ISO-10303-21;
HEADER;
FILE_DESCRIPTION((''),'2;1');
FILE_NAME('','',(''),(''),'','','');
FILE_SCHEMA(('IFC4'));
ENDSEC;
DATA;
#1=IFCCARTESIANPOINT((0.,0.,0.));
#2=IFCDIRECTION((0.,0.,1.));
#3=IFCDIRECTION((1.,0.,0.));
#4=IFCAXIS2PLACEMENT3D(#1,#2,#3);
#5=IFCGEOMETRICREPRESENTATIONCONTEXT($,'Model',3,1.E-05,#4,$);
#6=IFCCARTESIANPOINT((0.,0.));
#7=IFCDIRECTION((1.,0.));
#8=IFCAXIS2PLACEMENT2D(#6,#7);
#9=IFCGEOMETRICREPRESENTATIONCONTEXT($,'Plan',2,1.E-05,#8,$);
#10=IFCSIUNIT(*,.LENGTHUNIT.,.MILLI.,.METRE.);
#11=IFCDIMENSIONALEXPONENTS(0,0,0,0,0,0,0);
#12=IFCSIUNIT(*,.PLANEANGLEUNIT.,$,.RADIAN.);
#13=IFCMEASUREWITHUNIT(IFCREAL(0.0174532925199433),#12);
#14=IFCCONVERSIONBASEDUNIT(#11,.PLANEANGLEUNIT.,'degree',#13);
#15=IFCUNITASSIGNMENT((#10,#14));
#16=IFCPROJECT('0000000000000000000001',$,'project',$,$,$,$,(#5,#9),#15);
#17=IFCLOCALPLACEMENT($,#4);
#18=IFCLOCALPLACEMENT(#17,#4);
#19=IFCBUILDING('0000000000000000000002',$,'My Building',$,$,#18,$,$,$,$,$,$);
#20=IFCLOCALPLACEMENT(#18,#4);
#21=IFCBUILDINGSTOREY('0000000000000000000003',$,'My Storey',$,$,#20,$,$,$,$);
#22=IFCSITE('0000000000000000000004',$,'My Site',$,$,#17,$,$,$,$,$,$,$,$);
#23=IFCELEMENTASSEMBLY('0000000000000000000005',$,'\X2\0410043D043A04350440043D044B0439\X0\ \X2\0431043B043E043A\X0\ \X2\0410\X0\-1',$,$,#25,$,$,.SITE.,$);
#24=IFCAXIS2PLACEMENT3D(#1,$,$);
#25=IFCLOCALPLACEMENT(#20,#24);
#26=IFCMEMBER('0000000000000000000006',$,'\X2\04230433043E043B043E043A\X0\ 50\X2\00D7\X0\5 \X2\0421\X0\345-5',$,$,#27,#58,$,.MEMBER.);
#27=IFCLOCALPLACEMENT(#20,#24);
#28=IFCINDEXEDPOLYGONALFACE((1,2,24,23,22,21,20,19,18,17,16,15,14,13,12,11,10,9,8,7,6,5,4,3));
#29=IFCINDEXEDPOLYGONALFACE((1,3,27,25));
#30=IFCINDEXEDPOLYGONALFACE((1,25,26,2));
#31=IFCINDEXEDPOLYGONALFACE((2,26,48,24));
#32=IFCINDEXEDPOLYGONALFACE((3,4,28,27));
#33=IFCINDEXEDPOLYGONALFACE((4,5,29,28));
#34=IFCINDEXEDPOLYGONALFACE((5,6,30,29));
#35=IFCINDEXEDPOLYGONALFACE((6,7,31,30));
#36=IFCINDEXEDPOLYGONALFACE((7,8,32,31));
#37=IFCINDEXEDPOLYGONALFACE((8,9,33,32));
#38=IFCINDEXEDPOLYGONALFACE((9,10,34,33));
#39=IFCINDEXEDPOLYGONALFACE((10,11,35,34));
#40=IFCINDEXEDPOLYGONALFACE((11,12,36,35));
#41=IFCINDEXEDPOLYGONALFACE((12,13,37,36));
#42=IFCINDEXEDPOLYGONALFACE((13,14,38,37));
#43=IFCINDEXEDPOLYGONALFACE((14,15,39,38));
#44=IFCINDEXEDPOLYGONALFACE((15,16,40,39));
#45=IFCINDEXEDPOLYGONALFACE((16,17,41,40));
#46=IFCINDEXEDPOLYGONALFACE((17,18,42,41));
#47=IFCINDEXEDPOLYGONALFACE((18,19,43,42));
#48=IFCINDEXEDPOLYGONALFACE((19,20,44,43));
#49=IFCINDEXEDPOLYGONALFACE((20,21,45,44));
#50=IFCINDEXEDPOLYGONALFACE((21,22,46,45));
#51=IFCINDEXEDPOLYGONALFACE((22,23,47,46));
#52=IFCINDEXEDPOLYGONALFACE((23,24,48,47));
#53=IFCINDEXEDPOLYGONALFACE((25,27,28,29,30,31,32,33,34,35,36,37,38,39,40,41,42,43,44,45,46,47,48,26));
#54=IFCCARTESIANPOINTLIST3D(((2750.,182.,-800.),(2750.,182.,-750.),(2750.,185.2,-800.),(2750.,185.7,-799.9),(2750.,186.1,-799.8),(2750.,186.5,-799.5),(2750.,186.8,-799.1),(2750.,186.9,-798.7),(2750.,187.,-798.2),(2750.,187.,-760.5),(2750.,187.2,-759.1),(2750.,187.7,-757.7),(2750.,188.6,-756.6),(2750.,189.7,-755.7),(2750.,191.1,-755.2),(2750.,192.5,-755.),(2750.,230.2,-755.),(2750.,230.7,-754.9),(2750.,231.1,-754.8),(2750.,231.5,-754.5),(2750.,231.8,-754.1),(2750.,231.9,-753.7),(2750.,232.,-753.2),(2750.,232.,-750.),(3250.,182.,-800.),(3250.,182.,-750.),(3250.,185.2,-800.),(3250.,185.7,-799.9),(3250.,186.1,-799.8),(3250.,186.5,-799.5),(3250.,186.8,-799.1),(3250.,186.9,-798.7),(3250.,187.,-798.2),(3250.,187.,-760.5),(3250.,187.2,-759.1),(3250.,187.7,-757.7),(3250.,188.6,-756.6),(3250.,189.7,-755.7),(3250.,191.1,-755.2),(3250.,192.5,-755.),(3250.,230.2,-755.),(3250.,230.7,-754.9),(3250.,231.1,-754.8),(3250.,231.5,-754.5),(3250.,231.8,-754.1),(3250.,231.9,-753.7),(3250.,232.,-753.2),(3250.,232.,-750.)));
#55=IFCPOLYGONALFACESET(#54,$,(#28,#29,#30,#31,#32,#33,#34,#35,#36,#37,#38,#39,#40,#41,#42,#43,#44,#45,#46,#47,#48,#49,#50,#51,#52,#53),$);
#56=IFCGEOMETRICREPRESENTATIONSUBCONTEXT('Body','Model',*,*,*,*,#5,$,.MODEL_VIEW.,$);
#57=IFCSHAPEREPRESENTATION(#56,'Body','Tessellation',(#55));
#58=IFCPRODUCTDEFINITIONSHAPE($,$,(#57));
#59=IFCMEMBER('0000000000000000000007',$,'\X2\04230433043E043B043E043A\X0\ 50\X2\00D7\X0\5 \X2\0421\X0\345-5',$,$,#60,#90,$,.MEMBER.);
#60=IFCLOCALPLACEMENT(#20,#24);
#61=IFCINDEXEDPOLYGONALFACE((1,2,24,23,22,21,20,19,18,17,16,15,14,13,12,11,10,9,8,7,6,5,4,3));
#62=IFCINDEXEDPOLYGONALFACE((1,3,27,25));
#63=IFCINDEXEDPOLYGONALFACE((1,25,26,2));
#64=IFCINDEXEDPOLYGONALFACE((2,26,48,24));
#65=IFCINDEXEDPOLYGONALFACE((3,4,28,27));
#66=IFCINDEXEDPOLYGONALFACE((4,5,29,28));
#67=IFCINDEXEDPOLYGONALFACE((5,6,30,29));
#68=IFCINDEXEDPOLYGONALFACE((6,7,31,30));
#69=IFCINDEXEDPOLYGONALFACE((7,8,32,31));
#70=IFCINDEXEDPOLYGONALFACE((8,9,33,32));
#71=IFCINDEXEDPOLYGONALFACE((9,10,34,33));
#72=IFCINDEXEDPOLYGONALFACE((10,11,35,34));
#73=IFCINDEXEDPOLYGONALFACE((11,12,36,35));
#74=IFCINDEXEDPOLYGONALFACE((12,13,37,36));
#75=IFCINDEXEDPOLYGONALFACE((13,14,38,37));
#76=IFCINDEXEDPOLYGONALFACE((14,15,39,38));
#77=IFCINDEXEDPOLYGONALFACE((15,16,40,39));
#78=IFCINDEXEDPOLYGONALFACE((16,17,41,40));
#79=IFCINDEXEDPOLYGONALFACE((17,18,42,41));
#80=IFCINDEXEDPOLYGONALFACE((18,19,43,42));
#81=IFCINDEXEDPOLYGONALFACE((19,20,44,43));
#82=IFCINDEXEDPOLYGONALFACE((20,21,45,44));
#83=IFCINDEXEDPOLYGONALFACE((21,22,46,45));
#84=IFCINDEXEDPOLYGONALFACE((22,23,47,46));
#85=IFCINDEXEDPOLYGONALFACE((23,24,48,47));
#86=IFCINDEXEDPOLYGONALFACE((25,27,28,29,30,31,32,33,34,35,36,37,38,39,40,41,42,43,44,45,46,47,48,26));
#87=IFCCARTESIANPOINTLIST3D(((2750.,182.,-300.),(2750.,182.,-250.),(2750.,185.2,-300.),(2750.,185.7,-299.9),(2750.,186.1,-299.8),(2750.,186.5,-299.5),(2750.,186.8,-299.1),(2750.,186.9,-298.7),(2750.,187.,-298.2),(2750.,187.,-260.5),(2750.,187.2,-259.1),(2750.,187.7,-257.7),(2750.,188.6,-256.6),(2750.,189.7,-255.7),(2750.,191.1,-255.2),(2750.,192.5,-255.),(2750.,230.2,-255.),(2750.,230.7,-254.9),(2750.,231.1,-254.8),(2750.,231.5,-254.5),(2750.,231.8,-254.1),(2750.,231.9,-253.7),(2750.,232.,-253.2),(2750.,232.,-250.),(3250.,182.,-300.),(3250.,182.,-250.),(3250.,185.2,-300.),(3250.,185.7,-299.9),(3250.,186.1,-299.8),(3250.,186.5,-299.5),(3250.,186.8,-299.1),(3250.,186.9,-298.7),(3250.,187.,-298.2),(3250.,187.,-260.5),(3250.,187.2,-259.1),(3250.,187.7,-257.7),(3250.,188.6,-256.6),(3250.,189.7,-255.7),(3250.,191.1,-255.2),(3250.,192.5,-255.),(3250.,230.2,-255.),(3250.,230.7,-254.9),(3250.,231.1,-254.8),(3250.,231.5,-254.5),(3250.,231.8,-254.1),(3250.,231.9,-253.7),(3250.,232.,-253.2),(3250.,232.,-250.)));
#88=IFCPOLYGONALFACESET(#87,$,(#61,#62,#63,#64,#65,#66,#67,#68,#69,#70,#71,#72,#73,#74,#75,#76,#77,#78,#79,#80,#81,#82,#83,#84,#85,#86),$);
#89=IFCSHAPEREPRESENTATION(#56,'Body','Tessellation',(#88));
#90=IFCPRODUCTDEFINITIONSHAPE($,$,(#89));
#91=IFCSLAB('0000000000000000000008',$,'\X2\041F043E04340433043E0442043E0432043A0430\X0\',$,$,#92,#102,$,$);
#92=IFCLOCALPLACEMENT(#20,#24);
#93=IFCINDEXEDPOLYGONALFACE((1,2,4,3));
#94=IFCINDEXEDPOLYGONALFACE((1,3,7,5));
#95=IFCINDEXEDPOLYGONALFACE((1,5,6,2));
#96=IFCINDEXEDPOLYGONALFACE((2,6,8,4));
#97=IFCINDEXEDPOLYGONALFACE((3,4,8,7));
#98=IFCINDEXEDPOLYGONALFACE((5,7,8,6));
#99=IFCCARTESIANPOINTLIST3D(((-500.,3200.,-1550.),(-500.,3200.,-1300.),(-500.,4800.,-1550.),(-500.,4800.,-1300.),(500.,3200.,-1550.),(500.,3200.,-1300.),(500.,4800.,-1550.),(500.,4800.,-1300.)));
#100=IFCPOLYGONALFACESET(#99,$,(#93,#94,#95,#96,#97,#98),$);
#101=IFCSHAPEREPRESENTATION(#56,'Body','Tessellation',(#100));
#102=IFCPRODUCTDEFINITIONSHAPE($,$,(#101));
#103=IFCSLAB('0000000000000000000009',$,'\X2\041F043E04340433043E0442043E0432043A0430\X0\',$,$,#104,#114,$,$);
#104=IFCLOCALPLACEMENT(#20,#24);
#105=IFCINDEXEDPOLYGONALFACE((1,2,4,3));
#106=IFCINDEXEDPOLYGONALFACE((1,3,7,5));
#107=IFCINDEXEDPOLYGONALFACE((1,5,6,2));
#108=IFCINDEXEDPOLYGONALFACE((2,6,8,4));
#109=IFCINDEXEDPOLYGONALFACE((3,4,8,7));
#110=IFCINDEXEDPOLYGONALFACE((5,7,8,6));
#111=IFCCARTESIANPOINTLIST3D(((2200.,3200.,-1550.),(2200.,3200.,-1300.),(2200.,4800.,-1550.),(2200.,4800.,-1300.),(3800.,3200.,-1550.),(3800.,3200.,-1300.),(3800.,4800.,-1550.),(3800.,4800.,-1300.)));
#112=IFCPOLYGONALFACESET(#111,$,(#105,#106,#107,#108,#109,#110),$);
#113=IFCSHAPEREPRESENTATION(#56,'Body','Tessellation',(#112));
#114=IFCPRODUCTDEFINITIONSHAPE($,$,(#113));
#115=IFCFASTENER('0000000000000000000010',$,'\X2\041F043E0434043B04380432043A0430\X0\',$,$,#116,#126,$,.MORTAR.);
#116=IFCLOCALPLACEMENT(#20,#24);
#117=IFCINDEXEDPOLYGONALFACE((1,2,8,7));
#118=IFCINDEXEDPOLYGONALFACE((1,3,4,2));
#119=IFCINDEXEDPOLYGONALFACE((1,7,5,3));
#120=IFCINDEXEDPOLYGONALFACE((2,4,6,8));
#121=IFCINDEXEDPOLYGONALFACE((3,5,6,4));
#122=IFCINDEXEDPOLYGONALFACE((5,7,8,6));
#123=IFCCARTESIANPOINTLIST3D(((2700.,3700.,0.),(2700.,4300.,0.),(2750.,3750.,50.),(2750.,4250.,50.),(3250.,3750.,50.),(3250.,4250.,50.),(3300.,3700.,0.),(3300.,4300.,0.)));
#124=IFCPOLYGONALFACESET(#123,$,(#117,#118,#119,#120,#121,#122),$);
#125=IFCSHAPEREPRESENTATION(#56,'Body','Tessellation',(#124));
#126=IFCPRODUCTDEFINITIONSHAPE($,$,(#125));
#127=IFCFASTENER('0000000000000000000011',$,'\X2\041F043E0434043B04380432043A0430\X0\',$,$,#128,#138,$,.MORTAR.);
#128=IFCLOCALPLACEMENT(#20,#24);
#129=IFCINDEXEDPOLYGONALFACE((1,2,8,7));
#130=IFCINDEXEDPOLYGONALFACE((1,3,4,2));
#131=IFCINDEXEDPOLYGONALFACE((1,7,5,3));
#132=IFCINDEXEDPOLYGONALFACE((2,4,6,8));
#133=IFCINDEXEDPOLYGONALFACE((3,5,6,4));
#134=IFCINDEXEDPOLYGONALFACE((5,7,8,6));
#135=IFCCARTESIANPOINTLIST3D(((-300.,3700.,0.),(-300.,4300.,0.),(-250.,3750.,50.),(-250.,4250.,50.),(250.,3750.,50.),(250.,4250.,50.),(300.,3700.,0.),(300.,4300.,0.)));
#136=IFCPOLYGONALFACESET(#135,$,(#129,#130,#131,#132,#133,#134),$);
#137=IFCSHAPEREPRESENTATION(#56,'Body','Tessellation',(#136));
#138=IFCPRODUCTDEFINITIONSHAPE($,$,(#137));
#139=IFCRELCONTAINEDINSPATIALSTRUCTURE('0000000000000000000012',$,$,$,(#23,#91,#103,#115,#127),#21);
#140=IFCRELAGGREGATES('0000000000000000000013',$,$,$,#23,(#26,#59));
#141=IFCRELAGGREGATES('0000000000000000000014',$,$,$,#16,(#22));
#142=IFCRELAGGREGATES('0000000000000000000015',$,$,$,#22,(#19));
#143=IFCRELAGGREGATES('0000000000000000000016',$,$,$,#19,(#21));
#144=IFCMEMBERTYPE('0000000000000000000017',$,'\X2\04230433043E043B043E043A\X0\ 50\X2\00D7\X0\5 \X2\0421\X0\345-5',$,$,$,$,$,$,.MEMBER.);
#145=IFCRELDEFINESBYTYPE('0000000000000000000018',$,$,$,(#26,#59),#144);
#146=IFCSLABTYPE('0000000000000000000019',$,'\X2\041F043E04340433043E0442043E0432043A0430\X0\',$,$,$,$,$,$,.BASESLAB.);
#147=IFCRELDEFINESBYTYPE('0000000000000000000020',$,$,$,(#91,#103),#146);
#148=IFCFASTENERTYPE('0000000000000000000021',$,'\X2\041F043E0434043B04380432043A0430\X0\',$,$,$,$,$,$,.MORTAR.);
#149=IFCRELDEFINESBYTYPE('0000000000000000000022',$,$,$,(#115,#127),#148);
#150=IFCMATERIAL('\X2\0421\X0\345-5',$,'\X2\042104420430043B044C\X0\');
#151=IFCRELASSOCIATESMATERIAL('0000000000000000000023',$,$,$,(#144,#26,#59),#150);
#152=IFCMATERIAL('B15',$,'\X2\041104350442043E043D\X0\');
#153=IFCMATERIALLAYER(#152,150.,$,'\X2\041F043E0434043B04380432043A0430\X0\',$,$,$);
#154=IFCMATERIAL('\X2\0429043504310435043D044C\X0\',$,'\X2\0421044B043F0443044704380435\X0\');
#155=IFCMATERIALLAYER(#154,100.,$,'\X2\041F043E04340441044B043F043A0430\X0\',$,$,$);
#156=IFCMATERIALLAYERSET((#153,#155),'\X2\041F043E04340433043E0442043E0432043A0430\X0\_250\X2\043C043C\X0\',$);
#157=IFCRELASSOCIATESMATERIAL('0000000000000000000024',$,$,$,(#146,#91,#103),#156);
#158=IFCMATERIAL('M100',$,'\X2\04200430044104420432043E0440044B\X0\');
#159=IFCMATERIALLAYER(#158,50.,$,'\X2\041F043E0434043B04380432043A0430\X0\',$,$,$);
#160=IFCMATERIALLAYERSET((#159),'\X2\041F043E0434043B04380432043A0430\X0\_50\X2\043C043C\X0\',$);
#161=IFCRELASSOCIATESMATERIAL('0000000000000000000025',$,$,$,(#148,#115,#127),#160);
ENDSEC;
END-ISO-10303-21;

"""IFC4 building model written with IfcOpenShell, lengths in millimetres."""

from ifc_helpers import new_model, entity, si_unit, converted_unit, frame, origin_with_axes, origin_2d_with_axis, place, context, subcontext, project, spatial, line, indexed_curve, l_section, outline, extrude, clip, halfspace, material, layer, layer_set, layer_usage, material_profile, profile_set, profile_usage, type_object, element, aggregate, save


model = new_model("IFC4")

# Units and contexts
model_context = context("Model", 3, precision=1e-05, world=origin_with_axes())
plan_context = context("Plan", 2, precision=1e-05, world=origin_2d_with_axis())
body_context = subcontext(model_context, "Body", "Model", "MODEL_VIEW")
ifc_project = project(units=[si_unit("LENGTHUNIT", "METRE", prefix="MILLI"), converted_unit("PLANEANGLEUNIT", "degree", entity("IfcReal", 0.0174532925199433), si_unit("PLANEANGLEUNIT", "RADIAN"), dimensions=[0, 0, 0, 0, 0, 0, 0])], contexts=[model_context, plan_context])

# Site, building, storey
site_placement = place(None, origin_with_axes())
site = spatial("IfcSite", under=ifc_project, at=site_placement, Name="My Site")
building_placement = place(site_placement, origin_with_axes())
building = spatial("IfcBuilding", under=site, at=building_placement, Name="My Building")
storey_placement = place(building_placement, origin_with_axes())
storey = spatial("IfcBuildingStorey", under=building, at=storey_placement, Name="My Storey")

# Element assembly, members
assembly_1_placement = place(storey_placement, frame((3000.0, 0.0, 0.0), z_axis=(0.0, 0.0, 1.0), x_axis=(1.0, 0.0, 0.0)))
assembly_1 = element("IfcElementAssembly", 1, at=assembly_1_placement, inside=storey, Name="Анкерный блок А-1", AssemblyPlace="SITE")
ifc_material_1 = material(Name="С345-5", Category="Сталь")
ifc_material_profile = material_profile(ifc_material_1, l_section(Depth=50.0, Width=50.0, Thickness=5.0, FilletRadius=5.5, EdgeRadius=1.8))
ifc_profile_set = profile_set([ifc_material_profile])
ifc_profile_usage_1 = profile_usage(ifc_profile_set, cardinal=3)
member_type = type_object("IfcMemberType", Name="Уголок 50×5 С345-5", PredefinedType="MEMBER", material=ifc_profile_set)
member_1_placement = place(assembly_1_placement, frame((-250.0, 182.0, -750.0), z_axis=(1.0, 0.0, 0.000001), x_axis=(0.000001, 0.0, -1.0)))
member_1 = element("IfcMember", 2, at=member_1_placement, type_object=member_type, material=ifc_profile_usage_1, Name="Уголок 50×5 С345-5", PredefinedType="MEMBER", context=body_context, shape_type="SweptSolid", body=[
    extrude(l_section(Depth=50.0, Width=50.0, Thickness=5.0, FilletRadius=5.5, EdgeRadius=1.8), frame((25.0, 25.0, 0.0), z_axis=(0.0, 0.0, 1.0), x_axis=(1.0, 0.0, 0.0)), (0.0, 0.0, 1.0), 500.0),
])
ifc_profile_usage_2 = profile_usage(ifc_profile_set, cardinal=3)
member_2_placement = place(assembly_1_placement, frame((-250.0, 182.0, -250.0), z_axis=(1.0, 0.0, 0.000001), x_axis=(0.000001, 0.0, -1.0)))
member_2 = element("IfcMember", 3, at=member_2_placement, type_object=member_type, material=ifc_profile_usage_2, Name="Уголок 50×5 С345-5", PredefinedType="MEMBER", context=body_context, shape_type="SweptSolid", body=[
    extrude(l_section(Depth=50.0, Width=50.0, Thickness=5.0, FilletRadius=5.5, EdgeRadius=1.8), frame((25.0, 25.0, 0.0), z_axis=(0.0, 0.0, 1.0), x_axis=(1.0, 0.0, 0.0)), (0.0, 0.0, 1.0), 500.0),
])

# Slabs
ifc_material_2 = material(Name="B15", Category="Бетон")
ifc_layer_1 = layer(ifc_material_2, 150.0, Name="Подливка")
ifc_material_3 = material(Name="Щебень", Category="Сыпучие")
ifc_layer_2 = layer(ifc_material_3, 100.0, Name="Подсыпка")
ifc_layer_set_1 = layer_set([ifc_layer_1, ifc_layer_2], Name="Подготовка_250мм")
ifc_layer_usage_1 = layer_usage(ifc_layer_set_1, "AXIS3", "NEGATIVE", 0.0)
slab_type = type_object("IfcSlabType", Name="Подготовка", PredefinedType="BASESLAB", material=ifc_layer_set_1)
slab_1_placement = place(storey_placement, frame((0.0, 4000.0, -1550.0), z_axis=(0.0, 0.0, 1.0), x_axis=(1.0, 0.0, 0.0)))
element("IfcSlab", 4, at=slab_1_placement, inside=storey, type_object=slab_type, material=ifc_layer_usage_1, Name="Подготовка", context=body_context, shape_type="SweptSolid", body=[
    extrude(outline(indexed_curve([(-500.0, -800.0), (500.0, -800.0), (500.0, 800.0), (-500.0, 800.0)], segments=[line(3, 2), line(2, 1), line(1, 4), line(4, 3)], self_intersect=False)), None, (0.0, 0.0, 1.0), 250.0),
])
slab_2_placement = place(storey_placement, frame((3000.0, 4000.0, -1550.0), z_axis=(0.0, 0.0, 1.0), x_axis=(1.0, 0.0, 0.0)))
element("IfcSlab", 5, at=slab_2_placement, inside=storey, type_object=slab_type, material=ifc_layer_usage_1, Name="Подготовка", context=body_context, shape_type="SweptSolid", body=[
    extrude(outline(indexed_curve([(-800.0, -800.0), (800.0, -800.0), (800.0, 800.0), (-800.0, 800.0)], segments=[line(3, 2), line(2, 1), line(1, 4), line(4, 3)], self_intersect=False)), None, (0.0, 0.0, 1.0), 250.0),
])

# Fasteners
ifc_material_4 = material(Name="M100", Category="Растворы")
ifc_layer_3 = layer(ifc_material_4, 50.0, Name="Подливка")
ifc_layer_set_2 = layer_set([ifc_layer_3], Name="Подливка_50мм")
ifc_layer_usage_2 = layer_usage(ifc_layer_set_2, "AXIS3", "POSITIVE", 0.0)
fastener_type = type_object("IfcFastenerType", Name="Подливка", PredefinedType="MORTAR", material=ifc_layer_set_2)
fastener_1_placement = place(storey_placement, frame((3000.0, 4000.0, 0.0), z_axis=(0.0, 0.0, 1.0), x_axis=(1.0, 0.0, 0.0)))
element("IfcFastener", 6, at=fastener_1_placement, inside=storey, type_object=fastener_type, material=ifc_layer_usage_2, Name="Подливка", PredefinedType="MORTAR", context=body_context, shape_type="Clipping", body=[
    clip(clip(clip(clip(extrude(outline(indexed_curve([(-300.0, -300.0), (300.0, -300.0), (300.0, 300.0), (-300.0, 300.0)], segments=[line(3, 2), line(2, 1), line(1, 4), line(4, 3)], self_intersect=False)), None, (0.0, 0.0, 1.0), 50.0), halfspace(frame((-53.6, 200.0, 353.6), z_axis=(0.707107, 0.0, 0.707107), x_axis=(0.707107, 0.0, -0.707107)), False)), halfspace(frame((-200.0, -53.6, 353.6), z_axis=(0.0, 0.707107, 0.707107), x_axis=(0.0, 0.707107, -0.707107)), False)), halfspace(frame((200.0, 53.6, 353.6), z_axis=(0.0, -0.707107, 0.707107), x_axis=(0.0, -0.707107, -0.707107)), False)), halfspace(frame((53.6, 200.0, 353.6), z_axis=(-0.707107, 0.0, 0.707107), x_axis=(-0.707107, 0.0, -0.707107)), False)),
])
placement = place(storey_placement, frame((0.0, 4000.0, 0.0), z_axis=(0.0, 0.0, 1.0), x_axis=(1.0, 0.0, 0.0)))
element("IfcFastener", 7, at=placement, inside=storey, type_object=fastener_type, material=ifc_layer_usage_2, Name="Подливка", PredefinedType="MORTAR", context=body_context, shape_type="Clipping", body=[
    clip(clip(clip(clip(extrude(outline(indexed_curve([(-300.0, -300.0), (300.0, -300.0), (300.0, 300.0), (-300.0, 300.0)], segments=[line(3, 2), line(2, 1), line(1, 4), line(4, 3)], self_intersect=False)), None, (0.0, 0.0, 1.0), 50.0), halfspace(frame((-53.6, 200.0, 353.6), z_axis=(0.707107, 0.0, 0.707107), x_axis=(0.707107, 0.0, -0.707107)), False)), halfspace(frame((-200.0, -53.6, 353.6), z_axis=(0.0, 0.707107, 0.707107), x_axis=(0.0, 0.707107, -0.707107)), False)), halfspace(frame((200.0, 53.6, 353.6), z_axis=(0.0, -0.707107, 0.707107), x_axis=(0.0, -0.707107, -0.707107)), False)), halfspace(frame((53.6, 200.0, 353.6), z_axis=(-0.707107, 0.0, 0.707107), x_axis=(-0.707107, 0.0, -0.707107)), False)),
])

aggregate(assembly_1, [member_1, member_2])

save(model, "model.ifc")
